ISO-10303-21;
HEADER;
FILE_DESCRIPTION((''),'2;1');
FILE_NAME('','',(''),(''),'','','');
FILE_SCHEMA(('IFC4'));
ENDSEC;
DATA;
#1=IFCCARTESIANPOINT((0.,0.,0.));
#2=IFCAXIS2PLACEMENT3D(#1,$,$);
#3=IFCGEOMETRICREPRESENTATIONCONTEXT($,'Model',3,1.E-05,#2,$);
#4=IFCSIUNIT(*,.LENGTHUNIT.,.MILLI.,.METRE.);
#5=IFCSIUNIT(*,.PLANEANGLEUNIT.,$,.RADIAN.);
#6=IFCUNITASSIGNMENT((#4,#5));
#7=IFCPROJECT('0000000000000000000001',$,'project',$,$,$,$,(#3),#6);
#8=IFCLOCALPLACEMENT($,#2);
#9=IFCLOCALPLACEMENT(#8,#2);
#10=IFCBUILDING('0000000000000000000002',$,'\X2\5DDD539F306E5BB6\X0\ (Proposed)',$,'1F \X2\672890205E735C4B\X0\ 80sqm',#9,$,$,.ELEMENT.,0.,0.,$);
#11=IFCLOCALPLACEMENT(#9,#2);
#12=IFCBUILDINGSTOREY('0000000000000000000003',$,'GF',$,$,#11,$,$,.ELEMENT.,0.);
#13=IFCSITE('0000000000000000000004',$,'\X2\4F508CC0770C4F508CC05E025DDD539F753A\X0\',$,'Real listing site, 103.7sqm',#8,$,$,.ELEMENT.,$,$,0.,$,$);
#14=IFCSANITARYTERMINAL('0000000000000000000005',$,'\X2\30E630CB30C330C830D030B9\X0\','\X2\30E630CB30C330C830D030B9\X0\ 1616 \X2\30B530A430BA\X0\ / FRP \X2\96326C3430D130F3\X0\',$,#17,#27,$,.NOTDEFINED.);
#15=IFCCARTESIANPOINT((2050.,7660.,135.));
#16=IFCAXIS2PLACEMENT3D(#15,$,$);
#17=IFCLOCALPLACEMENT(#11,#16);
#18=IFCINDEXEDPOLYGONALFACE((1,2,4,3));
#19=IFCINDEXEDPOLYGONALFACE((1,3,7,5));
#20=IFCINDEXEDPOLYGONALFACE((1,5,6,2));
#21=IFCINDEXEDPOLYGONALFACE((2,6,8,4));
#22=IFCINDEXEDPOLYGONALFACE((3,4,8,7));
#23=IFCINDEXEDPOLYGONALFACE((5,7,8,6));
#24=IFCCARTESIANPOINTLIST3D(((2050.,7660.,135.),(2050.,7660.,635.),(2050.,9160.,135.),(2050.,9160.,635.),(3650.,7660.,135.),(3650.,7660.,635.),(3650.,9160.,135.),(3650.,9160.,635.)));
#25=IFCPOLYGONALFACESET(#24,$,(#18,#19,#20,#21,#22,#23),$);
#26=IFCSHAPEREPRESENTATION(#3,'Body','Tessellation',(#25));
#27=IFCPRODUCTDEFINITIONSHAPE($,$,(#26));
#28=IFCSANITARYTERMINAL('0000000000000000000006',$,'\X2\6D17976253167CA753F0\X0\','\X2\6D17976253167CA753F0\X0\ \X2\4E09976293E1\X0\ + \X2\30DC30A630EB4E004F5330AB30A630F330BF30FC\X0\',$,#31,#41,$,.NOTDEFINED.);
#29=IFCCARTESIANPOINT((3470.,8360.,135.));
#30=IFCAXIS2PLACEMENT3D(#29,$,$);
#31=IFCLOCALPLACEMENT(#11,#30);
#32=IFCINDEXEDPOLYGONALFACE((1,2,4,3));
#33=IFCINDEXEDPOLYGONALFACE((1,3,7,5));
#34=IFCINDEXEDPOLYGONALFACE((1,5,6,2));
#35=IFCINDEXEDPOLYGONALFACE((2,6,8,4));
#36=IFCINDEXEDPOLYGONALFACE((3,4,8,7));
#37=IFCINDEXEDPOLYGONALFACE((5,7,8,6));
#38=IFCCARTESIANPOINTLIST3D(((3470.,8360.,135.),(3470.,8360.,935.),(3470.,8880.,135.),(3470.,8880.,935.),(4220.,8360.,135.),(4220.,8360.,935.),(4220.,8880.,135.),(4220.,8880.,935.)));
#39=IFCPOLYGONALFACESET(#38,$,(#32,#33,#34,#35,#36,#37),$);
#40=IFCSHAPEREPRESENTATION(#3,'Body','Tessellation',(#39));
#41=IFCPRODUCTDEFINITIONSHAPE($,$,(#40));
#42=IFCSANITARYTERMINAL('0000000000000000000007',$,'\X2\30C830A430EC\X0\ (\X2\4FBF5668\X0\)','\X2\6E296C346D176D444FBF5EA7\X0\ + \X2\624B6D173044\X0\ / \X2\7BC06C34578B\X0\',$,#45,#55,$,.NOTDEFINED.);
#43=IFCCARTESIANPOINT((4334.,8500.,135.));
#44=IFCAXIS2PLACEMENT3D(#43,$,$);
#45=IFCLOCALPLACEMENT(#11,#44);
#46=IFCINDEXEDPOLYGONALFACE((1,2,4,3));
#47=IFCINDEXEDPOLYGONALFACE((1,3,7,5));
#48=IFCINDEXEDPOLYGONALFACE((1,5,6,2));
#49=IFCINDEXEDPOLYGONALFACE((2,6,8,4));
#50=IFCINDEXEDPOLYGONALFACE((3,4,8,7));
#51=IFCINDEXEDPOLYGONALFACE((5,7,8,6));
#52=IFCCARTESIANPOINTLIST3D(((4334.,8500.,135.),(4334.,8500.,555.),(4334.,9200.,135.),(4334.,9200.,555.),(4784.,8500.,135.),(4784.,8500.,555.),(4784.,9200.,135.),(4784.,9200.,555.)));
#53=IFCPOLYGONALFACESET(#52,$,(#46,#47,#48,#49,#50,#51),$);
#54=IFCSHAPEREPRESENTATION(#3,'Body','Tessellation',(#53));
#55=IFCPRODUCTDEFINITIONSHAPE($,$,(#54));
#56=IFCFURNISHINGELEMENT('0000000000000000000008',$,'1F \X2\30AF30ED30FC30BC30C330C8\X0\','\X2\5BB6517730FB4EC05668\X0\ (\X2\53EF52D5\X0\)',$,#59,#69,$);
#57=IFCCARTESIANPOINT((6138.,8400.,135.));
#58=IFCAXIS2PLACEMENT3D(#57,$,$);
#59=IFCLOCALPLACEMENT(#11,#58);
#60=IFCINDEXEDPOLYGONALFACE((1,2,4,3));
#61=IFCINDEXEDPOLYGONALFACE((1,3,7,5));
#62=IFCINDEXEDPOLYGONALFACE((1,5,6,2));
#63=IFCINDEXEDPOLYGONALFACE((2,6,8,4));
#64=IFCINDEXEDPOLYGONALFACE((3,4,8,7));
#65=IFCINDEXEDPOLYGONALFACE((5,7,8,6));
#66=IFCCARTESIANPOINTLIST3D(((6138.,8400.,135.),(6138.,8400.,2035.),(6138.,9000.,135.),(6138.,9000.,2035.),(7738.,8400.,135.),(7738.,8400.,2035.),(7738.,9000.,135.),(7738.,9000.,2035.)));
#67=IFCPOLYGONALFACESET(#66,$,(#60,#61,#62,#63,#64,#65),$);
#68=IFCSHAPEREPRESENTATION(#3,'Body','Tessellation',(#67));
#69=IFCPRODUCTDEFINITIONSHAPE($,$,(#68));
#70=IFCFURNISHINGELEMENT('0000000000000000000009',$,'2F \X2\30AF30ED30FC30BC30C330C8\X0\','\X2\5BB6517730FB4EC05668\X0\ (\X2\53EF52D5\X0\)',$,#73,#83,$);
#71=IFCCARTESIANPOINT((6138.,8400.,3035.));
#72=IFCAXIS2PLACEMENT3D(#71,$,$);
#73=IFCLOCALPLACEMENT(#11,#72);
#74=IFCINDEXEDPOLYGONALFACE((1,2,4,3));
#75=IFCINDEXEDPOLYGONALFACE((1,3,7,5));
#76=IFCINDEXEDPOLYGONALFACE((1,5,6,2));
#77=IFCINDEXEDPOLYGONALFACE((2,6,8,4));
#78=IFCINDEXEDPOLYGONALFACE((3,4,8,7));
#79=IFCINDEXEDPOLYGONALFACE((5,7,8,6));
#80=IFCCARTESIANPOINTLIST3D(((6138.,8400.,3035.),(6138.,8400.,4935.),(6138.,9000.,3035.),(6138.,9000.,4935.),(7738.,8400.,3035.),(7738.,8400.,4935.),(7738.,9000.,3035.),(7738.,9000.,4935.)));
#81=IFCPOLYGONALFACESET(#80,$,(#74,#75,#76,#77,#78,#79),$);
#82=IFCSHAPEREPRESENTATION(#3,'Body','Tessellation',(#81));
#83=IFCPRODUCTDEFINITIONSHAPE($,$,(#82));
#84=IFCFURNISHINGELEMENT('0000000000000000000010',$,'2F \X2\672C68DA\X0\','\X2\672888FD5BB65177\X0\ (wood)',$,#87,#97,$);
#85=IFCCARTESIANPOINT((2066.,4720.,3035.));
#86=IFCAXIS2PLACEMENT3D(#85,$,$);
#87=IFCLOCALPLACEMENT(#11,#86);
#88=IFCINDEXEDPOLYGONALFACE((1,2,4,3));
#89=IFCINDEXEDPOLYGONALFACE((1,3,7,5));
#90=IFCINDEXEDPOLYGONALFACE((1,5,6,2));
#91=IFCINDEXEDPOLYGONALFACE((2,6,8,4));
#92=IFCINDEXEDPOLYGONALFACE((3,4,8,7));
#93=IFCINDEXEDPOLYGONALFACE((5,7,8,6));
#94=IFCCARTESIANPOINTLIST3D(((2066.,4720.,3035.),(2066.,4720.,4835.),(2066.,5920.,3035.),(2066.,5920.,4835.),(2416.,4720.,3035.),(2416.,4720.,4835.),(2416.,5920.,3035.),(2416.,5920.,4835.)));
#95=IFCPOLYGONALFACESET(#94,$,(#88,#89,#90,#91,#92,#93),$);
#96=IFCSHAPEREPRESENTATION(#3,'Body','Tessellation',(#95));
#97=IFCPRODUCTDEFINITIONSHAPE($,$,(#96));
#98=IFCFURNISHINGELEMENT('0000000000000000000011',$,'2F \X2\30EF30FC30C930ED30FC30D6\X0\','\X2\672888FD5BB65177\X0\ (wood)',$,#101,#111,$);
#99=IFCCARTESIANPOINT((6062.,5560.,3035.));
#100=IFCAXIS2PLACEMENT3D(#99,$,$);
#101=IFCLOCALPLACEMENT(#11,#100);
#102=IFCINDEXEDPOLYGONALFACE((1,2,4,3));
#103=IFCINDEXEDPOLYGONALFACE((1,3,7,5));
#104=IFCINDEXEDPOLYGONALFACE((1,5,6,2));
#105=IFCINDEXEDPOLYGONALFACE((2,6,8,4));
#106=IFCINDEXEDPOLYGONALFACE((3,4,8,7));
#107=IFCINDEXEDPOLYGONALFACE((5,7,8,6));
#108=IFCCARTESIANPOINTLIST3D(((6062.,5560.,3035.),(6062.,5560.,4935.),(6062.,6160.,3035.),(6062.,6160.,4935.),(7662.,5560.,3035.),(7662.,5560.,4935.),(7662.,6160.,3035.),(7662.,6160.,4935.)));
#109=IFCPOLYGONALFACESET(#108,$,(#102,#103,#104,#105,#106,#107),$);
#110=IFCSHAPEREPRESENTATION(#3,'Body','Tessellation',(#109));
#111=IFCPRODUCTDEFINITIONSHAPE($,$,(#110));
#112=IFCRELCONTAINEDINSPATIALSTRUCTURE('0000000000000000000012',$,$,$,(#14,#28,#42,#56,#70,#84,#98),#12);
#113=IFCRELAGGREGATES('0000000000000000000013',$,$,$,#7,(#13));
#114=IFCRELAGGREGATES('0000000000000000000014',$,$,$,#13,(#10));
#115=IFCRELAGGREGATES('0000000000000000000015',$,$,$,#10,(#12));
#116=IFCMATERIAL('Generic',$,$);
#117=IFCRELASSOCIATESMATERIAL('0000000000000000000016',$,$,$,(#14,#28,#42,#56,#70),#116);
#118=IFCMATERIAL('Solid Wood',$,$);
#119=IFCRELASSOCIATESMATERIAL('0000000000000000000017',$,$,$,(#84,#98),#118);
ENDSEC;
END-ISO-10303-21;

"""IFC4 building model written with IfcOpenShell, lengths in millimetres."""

from ifc_helpers import new_model, si_unit, frame, frame_2d, origin, place, context, project, spatial, rectangle, extrude, material, element, save


model = new_model("IFC4")

# Units and contexts
model_context = context("Model", 3, precision=1e-05, world=origin())
ifc_project = project(units=[si_unit("LENGTHUNIT", "METRE", prefix="MILLI"), si_unit("PLANEANGLEUNIT", "RADIAN")], contexts=[model_context])

# Site, building, storey
site_placement = place(None, origin())
site = spatial("IfcSite", under=ifc_project, at=site_placement, Name="佐賀県佐賀市川原町", ObjectType="Real listing site, 103.7sqm", CompositionType="ELEMENT", RefElevation=0.0)
building_placement = place(site_placement, origin())
building = spatial("IfcBuilding", under=site, at=building_placement, Name="川原の家 (Proposed)", ObjectType="1F 木造平屋 80sqm", CompositionType="ELEMENT", ElevationOfRefHeight=0.0, ElevationOfTerrain=0.0)
storey_placement = place(building_placement, origin())
storey = spatial("IfcBuildingStorey", under=building, at=storey_placement, Name="GF", CompositionType="ELEMENT", Elevation=0.0)

# Shared definitions
ifc_material_1 = material(Name="Solid Wood")

# Shared definitions
ifc_material_2 = material(Name="Generic")

# Sanitary terminals
sanitary_terminal_1_placement = place(storey_placement, frame((2050.0, 7660.0, 135.0)))
element("IfcSanitaryTerminal", 1, at=sanitary_terminal_1_placement, inside=storey, material=ifc_material_2, Name="ユニットバス", Description="ユニットバス 1616 サイズ / FRP 防水パン", PredefinedType="NOTDEFINED", context=model_context, shape_type="SweptSolid", body=[
    extrude(rectangle(XDim=1600.0, YDim=1500.0, at=frame_2d((800.0, 750.0))), frame((2050.0, 7660.0, 135.0)), (0.0, 0.0, 1.0), 500.0),
])
sanitary_terminal_2_placement = place(storey_placement, frame((3470.0, 8360.0, 135.0)))
element("IfcSanitaryTerminal", 2, at=sanitary_terminal_2_placement, inside=storey, material=ifc_material_2, Name="洗面化粧台", Description="洗面化粧台 三面鏡 + ボウル一体カウンター", PredefinedType="NOTDEFINED", context=model_context, shape_type="SweptSolid", body=[
    extrude(rectangle(XDim=750.0, YDim=520.0, at=frame_2d((375.0, 260.0))), frame((3470.0, 8360.0, 135.0)), (0.0, 0.0, 1.0), 800.0),
])
sanitary_terminal_3_placement = place(storey_placement, frame((4334.0, 8500.0, 135.0)))
element("IfcSanitaryTerminal", 3, at=sanitary_terminal_3_placement, inside=storey, material=ifc_material_2, Name="トイレ (便器)", Description="温水洗浄便座 + 手洗い / 節水型", PredefinedType="NOTDEFINED", context=model_context, shape_type="SweptSolid", body=[
    extrude(rectangle(XDim=450.0, YDim=700.0, at=frame_2d((225.0, 350.0))), frame((4334.0, 8500.0, 135.0)), (0.0, 0.0, 1.0), 420.0),
])

# Furnishing elements
furnishing_1_placement = place(storey_placement, frame((6138.0, 8400.0, 135.0)))
element("IfcFurnishingElement", 4, at=furnishing_1_placement, inside=storey, material=ifc_material_2, Name="1F クローゼット", Description="家具・什器 (可動)", context=model_context, shape_type="SweptSolid", body=[
    extrude(rectangle(XDim=1600.0, YDim=600.0, at=frame_2d((800.0, 300.0))), frame((6138.0, 8400.0, 135.0)), (0.0, 0.0, 1.0), 1900.0),
])
furnishing_2_placement = place(storey_placement, frame((6138.0, 8400.0, 3035.0)))
element("IfcFurnishingElement", 5, at=furnishing_2_placement, inside=storey, material=ifc_material_2, Name="2F クローゼット", Description="家具・什器 (可動)", context=model_context, shape_type="SweptSolid", body=[
    extrude(rectangle(XDim=1600.0, YDim=600.0, at=frame_2d((800.0, 300.0))), frame((6138.0, 8400.0, 3035.0)), (0.0, 0.0, 1.0), 1900.0),
])
furnishing_3_placement = place(storey_placement, frame((2066.0, 4720.0, 3035.0)))
element("IfcFurnishingElement", 6, at=furnishing_3_placement, inside=storey, material=ifc_material_1, Name="2F 本棚", Description="木製家具 (wood)", context=model_context, shape_type="SweptSolid", body=[
    extrude(rectangle(XDim=350.0, YDim=1200.0, at=frame_2d((175.0, 600.0))), frame((2066.0, 4720.0, 3035.0)), (0.0, 0.0, 1.0), 1800.0),
])
furnishing_4_placement = place(storey_placement, frame((6062.0, 5560.0, 3035.0)))
element("IfcFurnishingElement", 7, at=furnishing_4_placement, inside=storey, material=ifc_material_1, Name="2F ワードローブ", Description="木製家具 (wood)", context=model_context, shape_type="SweptSolid", body=[
    extrude(rectangle(XDim=1600.0, YDim=600.0, at=frame_2d((800.0, 300.0))), frame((6062.0, 5560.0, 3035.0)), (0.0, 0.0, 1.0), 1900.0),
])

save(model, "model.ifc")
